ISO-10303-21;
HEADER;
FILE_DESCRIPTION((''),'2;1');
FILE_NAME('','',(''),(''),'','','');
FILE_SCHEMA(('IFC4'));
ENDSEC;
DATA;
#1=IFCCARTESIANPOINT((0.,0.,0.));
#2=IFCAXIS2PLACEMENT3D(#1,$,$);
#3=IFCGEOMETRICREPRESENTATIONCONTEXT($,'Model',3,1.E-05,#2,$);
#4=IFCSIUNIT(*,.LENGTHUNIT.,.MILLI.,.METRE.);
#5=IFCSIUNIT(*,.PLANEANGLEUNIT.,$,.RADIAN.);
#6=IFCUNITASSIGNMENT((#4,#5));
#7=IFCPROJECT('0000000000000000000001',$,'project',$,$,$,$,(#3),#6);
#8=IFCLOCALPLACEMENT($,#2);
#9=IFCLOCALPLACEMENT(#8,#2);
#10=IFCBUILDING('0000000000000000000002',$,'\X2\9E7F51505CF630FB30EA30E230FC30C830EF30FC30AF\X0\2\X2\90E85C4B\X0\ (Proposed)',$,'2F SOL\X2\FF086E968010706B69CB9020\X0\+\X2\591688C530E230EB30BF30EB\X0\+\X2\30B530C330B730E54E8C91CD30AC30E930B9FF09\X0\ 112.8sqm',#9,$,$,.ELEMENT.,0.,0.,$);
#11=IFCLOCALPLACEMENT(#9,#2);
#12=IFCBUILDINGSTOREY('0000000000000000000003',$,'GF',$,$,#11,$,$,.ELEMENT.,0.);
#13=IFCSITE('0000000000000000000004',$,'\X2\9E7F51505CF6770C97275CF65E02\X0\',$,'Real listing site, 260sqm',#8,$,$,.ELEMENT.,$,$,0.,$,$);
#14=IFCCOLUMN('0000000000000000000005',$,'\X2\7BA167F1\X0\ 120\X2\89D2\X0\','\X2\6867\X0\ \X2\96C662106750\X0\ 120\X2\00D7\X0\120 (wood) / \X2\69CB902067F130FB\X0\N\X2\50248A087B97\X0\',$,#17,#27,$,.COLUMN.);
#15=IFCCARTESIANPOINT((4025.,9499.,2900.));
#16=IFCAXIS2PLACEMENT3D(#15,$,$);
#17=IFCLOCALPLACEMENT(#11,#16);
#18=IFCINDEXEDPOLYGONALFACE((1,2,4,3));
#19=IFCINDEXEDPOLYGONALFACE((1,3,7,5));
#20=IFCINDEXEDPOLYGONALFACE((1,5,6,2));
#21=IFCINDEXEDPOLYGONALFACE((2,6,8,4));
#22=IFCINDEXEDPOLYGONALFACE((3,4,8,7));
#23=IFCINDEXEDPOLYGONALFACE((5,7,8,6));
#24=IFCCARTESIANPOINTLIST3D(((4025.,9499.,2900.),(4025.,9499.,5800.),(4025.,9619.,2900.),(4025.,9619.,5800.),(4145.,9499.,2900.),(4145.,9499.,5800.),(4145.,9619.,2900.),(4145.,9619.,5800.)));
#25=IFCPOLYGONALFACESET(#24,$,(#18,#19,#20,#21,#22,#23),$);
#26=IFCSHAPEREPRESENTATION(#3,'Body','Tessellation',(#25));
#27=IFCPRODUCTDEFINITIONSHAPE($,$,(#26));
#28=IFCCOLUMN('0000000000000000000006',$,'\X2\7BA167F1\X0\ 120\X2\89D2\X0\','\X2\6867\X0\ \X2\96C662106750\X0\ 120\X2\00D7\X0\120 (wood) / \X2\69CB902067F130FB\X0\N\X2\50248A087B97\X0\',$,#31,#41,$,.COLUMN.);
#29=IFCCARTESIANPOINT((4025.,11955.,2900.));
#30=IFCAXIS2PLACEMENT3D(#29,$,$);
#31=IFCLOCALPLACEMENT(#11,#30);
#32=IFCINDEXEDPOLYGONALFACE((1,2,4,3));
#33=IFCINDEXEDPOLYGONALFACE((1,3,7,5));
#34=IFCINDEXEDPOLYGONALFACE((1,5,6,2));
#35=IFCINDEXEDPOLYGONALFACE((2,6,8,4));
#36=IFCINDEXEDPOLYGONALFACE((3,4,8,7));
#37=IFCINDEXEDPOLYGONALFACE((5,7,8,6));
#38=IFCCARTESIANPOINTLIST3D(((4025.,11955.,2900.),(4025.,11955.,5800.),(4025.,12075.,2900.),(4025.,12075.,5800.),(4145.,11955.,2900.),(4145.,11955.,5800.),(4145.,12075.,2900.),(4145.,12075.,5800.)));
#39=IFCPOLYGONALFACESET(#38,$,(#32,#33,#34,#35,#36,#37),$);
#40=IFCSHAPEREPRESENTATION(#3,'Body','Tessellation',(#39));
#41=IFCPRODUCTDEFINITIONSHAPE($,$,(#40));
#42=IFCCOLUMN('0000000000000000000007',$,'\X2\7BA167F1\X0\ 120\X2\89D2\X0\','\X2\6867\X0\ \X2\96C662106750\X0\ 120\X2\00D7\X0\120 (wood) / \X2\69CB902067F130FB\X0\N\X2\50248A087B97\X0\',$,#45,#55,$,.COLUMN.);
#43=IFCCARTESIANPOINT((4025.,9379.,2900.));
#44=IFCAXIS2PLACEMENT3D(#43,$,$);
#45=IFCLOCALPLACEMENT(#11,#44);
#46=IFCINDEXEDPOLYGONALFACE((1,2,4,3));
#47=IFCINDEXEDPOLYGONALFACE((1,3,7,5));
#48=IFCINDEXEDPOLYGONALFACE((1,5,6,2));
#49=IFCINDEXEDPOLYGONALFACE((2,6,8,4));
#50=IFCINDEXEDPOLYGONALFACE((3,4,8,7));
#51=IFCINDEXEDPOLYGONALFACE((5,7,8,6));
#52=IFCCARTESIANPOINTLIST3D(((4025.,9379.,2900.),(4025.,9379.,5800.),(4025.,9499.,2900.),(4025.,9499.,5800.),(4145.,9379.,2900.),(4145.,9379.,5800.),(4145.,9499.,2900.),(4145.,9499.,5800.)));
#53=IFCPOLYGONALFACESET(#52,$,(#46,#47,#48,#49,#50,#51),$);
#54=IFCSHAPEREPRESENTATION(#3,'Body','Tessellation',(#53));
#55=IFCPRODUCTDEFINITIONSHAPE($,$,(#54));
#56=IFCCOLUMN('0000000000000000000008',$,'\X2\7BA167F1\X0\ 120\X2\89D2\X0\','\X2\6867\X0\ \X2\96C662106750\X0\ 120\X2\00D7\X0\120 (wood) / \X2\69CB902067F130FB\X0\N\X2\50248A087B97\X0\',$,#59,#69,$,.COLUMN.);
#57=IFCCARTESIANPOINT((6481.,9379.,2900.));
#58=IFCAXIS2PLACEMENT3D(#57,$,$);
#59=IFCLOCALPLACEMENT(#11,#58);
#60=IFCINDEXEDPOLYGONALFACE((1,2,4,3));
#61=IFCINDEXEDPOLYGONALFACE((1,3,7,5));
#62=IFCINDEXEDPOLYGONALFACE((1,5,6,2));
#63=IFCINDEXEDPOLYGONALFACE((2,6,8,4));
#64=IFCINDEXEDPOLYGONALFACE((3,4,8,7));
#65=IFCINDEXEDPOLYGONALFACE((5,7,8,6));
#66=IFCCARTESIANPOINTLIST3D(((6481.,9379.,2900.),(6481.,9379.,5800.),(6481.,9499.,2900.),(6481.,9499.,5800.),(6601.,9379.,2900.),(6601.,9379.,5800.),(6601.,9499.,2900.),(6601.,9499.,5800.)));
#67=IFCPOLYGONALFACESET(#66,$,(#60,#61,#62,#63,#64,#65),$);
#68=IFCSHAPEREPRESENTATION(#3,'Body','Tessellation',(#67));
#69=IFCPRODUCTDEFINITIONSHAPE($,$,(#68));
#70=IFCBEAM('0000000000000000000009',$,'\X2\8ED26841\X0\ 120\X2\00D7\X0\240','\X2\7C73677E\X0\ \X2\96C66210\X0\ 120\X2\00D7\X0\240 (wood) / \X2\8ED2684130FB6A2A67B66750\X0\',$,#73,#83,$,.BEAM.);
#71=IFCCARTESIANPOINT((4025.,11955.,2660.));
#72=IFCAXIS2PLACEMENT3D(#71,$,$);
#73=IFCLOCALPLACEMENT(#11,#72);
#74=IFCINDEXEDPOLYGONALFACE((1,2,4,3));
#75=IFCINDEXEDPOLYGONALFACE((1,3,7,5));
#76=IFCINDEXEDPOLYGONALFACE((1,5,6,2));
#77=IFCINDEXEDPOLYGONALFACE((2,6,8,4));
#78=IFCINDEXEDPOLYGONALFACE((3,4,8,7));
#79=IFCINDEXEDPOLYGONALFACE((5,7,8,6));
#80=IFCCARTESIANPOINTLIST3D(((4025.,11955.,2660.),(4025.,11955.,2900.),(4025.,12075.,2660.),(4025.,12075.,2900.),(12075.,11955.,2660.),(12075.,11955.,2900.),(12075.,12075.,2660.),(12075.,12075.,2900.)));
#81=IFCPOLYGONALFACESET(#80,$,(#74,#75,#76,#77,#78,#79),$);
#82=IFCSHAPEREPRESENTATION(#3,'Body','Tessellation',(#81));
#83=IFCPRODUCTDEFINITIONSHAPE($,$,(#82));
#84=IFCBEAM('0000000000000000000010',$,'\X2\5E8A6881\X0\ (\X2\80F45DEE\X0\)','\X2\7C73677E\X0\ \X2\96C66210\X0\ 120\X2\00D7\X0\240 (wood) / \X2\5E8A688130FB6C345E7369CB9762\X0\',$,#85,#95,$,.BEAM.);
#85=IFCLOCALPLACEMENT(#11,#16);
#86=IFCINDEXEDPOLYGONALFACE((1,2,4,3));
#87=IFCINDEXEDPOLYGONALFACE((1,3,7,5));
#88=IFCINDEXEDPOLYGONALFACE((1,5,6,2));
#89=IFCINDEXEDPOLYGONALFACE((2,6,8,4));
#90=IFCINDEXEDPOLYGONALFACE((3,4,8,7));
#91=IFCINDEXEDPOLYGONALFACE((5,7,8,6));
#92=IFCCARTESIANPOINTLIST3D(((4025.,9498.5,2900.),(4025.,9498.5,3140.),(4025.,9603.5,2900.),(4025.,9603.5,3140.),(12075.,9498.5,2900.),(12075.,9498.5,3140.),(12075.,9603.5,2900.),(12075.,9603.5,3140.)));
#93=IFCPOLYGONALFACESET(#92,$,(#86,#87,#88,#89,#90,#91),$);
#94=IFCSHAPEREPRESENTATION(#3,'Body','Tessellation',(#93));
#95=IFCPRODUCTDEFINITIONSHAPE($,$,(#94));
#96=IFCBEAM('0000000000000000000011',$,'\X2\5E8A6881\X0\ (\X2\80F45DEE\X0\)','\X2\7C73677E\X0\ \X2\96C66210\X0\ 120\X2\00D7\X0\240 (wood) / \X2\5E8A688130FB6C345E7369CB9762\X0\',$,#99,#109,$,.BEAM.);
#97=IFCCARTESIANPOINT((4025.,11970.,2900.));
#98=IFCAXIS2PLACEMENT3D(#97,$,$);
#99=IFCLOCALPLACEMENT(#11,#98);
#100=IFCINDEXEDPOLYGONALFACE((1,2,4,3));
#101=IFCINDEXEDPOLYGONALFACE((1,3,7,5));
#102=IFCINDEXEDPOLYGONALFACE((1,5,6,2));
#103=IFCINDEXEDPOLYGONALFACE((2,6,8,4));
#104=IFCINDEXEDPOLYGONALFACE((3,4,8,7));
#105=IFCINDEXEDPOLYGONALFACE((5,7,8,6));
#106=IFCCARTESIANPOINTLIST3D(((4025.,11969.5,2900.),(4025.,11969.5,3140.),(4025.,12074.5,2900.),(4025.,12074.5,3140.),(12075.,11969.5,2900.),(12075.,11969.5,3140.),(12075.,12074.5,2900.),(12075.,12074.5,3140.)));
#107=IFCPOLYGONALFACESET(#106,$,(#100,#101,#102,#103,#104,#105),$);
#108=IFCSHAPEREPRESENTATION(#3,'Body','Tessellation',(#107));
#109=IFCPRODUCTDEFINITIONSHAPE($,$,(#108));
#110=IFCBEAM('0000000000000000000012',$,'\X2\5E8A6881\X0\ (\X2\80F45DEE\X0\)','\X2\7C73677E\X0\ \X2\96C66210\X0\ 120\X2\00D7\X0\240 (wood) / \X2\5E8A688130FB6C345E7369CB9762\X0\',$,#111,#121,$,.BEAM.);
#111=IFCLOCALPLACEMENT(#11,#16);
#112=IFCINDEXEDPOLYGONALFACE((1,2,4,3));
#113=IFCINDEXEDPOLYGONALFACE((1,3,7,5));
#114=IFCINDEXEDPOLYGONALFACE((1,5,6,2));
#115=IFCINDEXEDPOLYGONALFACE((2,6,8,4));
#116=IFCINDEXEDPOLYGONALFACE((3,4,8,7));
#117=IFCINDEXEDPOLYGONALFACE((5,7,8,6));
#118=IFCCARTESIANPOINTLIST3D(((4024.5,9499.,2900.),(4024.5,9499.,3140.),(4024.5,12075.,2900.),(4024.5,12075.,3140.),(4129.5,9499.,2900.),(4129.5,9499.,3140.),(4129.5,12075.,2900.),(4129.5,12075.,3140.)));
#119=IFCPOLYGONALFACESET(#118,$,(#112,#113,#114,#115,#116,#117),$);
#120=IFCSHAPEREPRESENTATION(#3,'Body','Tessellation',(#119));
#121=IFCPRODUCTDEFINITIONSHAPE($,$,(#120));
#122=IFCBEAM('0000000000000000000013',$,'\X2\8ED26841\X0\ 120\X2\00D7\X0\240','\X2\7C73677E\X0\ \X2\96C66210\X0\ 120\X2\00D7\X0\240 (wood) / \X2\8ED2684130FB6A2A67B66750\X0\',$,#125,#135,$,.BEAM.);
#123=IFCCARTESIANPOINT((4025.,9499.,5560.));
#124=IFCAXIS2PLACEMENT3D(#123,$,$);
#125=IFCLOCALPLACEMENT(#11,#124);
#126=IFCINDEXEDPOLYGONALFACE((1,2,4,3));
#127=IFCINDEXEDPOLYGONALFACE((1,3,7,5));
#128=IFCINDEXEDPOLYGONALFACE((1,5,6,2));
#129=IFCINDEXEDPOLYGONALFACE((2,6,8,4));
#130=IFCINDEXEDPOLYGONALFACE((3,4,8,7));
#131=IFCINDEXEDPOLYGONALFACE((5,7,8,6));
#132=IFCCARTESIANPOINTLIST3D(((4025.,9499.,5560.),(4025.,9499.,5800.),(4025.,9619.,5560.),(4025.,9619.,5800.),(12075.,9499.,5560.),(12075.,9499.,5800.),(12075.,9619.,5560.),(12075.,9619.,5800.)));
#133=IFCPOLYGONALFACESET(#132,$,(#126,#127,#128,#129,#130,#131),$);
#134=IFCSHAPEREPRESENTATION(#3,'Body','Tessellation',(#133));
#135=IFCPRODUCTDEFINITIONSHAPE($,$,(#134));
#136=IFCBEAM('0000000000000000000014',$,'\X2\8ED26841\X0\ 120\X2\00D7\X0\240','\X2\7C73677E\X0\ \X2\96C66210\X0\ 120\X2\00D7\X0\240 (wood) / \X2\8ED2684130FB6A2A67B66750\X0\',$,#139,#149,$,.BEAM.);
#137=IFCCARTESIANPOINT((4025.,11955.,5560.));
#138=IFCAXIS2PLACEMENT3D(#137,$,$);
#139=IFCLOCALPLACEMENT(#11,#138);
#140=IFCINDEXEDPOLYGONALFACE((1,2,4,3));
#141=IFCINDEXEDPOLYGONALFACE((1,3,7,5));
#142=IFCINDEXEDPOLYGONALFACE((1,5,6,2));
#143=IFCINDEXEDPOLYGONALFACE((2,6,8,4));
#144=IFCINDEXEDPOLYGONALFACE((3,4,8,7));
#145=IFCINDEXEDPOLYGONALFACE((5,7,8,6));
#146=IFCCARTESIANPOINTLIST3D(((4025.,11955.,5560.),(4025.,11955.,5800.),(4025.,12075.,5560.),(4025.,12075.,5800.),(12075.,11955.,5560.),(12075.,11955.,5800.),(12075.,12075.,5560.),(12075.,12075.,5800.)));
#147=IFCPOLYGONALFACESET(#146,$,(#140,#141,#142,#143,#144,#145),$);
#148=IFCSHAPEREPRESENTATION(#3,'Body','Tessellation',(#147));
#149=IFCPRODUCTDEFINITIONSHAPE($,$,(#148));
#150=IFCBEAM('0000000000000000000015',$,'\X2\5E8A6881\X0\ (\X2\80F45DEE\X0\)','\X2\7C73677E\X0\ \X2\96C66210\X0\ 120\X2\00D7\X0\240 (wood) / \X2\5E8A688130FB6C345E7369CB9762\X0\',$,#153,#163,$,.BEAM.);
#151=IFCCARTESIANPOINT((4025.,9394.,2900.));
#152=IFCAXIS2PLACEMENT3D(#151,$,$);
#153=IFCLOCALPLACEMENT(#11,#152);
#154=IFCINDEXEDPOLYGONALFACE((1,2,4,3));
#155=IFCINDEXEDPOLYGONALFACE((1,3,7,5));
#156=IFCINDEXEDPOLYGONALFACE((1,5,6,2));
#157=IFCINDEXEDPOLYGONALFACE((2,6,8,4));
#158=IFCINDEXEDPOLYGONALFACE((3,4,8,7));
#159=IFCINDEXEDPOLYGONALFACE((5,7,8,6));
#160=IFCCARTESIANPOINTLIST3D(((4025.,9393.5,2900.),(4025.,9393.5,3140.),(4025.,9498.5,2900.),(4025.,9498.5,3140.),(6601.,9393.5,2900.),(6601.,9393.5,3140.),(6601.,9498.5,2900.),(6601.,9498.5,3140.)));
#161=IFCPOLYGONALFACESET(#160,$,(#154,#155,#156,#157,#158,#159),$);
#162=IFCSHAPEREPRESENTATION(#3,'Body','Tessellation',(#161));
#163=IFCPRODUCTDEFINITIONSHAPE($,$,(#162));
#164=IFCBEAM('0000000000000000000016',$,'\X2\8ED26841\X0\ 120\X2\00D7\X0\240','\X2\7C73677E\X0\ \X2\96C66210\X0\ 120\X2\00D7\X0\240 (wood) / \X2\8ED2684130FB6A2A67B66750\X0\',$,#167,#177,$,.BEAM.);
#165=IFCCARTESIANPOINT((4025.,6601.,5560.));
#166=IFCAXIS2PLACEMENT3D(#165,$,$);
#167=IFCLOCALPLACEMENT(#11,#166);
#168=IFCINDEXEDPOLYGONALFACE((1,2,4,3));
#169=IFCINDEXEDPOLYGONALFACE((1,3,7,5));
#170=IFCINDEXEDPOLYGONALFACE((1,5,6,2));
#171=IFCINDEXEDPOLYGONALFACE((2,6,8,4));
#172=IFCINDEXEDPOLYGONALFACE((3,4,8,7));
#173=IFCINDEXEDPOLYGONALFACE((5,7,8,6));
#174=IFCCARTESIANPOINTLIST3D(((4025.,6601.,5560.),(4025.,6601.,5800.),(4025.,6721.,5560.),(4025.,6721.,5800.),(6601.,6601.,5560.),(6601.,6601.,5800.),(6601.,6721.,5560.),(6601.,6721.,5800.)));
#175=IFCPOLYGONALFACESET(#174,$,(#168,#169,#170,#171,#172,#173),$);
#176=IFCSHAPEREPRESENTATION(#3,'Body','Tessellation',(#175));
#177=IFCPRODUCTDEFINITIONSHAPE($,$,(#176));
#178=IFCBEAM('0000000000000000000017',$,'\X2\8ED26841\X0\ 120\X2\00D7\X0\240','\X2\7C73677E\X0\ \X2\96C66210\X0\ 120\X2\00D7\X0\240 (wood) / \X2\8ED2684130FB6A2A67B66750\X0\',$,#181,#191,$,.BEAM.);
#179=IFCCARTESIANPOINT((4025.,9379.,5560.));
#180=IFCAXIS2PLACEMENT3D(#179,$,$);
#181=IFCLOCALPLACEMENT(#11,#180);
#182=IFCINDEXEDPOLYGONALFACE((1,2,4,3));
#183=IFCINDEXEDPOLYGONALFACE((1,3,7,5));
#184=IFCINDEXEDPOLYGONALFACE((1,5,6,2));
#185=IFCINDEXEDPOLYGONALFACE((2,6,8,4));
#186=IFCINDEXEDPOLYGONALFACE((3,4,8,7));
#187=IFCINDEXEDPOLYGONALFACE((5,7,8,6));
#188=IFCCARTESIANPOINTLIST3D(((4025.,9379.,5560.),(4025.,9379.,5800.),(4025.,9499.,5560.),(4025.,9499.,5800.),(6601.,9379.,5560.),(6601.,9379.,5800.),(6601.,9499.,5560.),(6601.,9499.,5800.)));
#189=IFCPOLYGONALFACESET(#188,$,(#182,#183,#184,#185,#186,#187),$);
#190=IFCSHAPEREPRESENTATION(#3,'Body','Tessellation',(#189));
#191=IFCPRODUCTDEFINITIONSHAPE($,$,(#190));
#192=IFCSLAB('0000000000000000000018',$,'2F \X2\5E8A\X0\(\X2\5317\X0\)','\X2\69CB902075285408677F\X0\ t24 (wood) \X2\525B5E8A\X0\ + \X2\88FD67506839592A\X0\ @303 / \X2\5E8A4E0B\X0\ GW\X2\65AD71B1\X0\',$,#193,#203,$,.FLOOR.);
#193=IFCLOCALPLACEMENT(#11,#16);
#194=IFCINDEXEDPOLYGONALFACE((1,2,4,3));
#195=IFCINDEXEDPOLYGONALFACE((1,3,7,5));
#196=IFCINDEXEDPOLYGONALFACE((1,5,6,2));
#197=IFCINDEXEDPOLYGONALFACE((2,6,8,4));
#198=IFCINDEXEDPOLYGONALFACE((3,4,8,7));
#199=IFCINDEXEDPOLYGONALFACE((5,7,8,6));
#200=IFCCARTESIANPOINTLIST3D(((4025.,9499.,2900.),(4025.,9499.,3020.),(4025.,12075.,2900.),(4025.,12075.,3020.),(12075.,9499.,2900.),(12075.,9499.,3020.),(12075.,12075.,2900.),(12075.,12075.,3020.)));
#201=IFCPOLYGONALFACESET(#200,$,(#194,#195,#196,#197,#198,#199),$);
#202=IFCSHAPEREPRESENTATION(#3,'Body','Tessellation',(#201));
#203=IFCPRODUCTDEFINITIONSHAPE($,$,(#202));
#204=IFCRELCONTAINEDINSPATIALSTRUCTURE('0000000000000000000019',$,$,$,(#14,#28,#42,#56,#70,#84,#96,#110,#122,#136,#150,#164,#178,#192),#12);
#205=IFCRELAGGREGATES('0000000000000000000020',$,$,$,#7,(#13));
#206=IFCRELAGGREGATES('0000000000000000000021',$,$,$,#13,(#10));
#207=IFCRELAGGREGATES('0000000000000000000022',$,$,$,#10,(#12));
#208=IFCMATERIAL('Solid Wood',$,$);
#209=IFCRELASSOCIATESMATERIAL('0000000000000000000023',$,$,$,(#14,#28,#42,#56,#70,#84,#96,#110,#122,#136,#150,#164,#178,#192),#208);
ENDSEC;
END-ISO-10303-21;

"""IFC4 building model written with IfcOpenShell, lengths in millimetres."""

from ifc_helpers import new_model, si_unit, frame, frame_2d, origin, place, context, project, spatial, rectangle, extrude, material, element, save


model = new_model("IFC4")

# Units and contexts
model_context = context("Model", 3, precision=1e-05, world=origin())
ifc_project = project(units=[si_unit("LENGTHUNIT", "METRE", prefix="MILLI"), si_unit("PLANEANGLEUNIT", "RADIAN")], contexts=[model_context])

# Site, building, storey
site_placement = place(None, origin())
site = spatial("IfcSite", under=ifc_project, at=site_placement, Name="鹿児島県霧島市", ObjectType="Real listing site, 260sqm", CompositionType="ELEMENT", RefElevation=0.0)
building_placement = place(site_placement, origin())
building = spatial("IfcBuilding", under=site, at=building_placement, Name="鹿児島・リモートワーク2部屋 (Proposed)", ObjectType="2F SOL（準耐火構造+外装モルタル+サッシュ二重ガラス） 112.8sqm", CompositionType="ELEMENT", ElevationOfRefHeight=0.0, ElevationOfTerrain=0.0)
storey_placement = place(building_placement, origin())
storey = spatial("IfcBuildingStorey", under=building, at=storey_placement, Name="GF", CompositionType="ELEMENT", Elevation=0.0)

# Columns
ifc_material_1 = material(Name="Solid Wood")
column_1_placement = place(storey_placement, frame((4025.0, 9499.0, 2900.0)))
element("IfcColumn", 1, at=column_1_placement, inside=storey, material=ifc_material_1, Name="管柱 120角", Description="桧 集成材 120×120 (wood) / 構造柱・N値計算", PredefinedType="COLUMN", context=model_context, shape_type="SweptSolid", body=[
    extrude(rectangle(XDim=120.0, YDim=120.0, at=frame_2d((60.0, 60.0))), frame((4025.0, 9499.0, 2900.0)), (0.0, 0.0, 1.0), 2900.0),
])
column_2_placement = place(storey_placement, frame((4025.0, 11955.0, 2900.0)))
element("IfcColumn", 2, at=column_2_placement, inside=storey, material=ifc_material_1, Name="管柱 120角", Description="桧 集成材 120×120 (wood) / 構造柱・N値計算", PredefinedType="COLUMN", context=model_context, shape_type="SweptSolid", body=[
    extrude(rectangle(XDim=120.0, YDim=120.0, at=frame_2d((60.0, 60.0))), frame((4025.0, 11955.0, 2900.0)), (0.0, 0.0, 1.0), 2900.0),
])
column_3_placement = place(storey_placement, frame((4025.0, 9379.0, 2900.0)))
element("IfcColumn", 3, at=column_3_placement, inside=storey, material=ifc_material_1, Name="管柱 120角", Description="桧 集成材 120×120 (wood) / 構造柱・N値計算", PredefinedType="COLUMN", context=model_context, shape_type="SweptSolid", body=[
    extrude(rectangle(XDim=120.0, YDim=120.0, at=frame_2d((60.0, 60.0))), frame((4025.0, 9379.0, 2900.0)), (0.0, 0.0, 1.0), 2900.0),
])
column_4_placement = place(storey_placement, frame((6481.0, 9379.0, 2900.0)))
element("IfcColumn", 4, at=column_4_placement, inside=storey, material=ifc_material_1, Name="管柱 120角", Description="桧 集成材 120×120 (wood) / 構造柱・N値計算", PredefinedType="COLUMN", context=model_context, shape_type="SweptSolid", body=[
    extrude(rectangle(XDim=120.0, YDim=120.0, at=frame_2d((60.0, 60.0))), frame((6481.0, 9379.0, 2900.0)), (0.0, 0.0, 1.0), 2900.0),
])

# Beams
beam_1_placement = place(storey_placement, frame((4025.0, 11955.0, 2660.0)))
element("IfcBeam", 5, at=beam_1_placement, inside=storey, material=ifc_material_1, Name="軒桁 120×240", Description="米松 集成 120×240 (wood) / 軒桁・横架材", PredefinedType="BEAM", context=model_context, shape_type="SweptSolid", body=[
    extrude(rectangle(XDim=8050.0, YDim=120.0, at=frame_2d((4025.0, 60.0))), frame((4025.0, 11955.0, 2660.0)), (0.0, 0.0, 1.0), 240.0),
])
beam_2_placement = place(storey_placement, frame((4025.0, 9499.0, 2900.0)))
element("IfcBeam", 6, at=beam_2_placement, inside=storey, material=ifc_material_1, Name="床梁 (胴差)", Description="米松 集成 120×240 (wood) / 床梁・水平構面", PredefinedType="BEAM", context=model_context, shape_type="SweptSolid", body=[
    extrude(rectangle(XDim=8050.0, YDim=105.0, at=frame_2d((4025.0, 52.0))), frame((4025.0, 9499.0, 2900.0)), (0.0, 0.0, 1.0), 240.0),
])
beam_3_placement = place(storey_placement, frame((4025.0, 11970.0, 2900.0)))
element("IfcBeam", 7, at=beam_3_placement, inside=storey, material=ifc_material_1, Name="床梁 (胴差)", Description="米松 集成 120×240 (wood) / 床梁・水平構面", PredefinedType="BEAM", context=model_context, shape_type="SweptSolid", body=[
    extrude(rectangle(XDim=8050.0, YDim=105.0, at=frame_2d((4025.0, 52.0))), frame((4025.0, 11970.0, 2900.0)), (0.0, 0.0, 1.0), 240.0),
])
beam_4_placement = place(storey_placement, frame((4025.0, 9499.0, 2900.0)))
element("IfcBeam", 8, at=beam_4_placement, inside=storey, material=ifc_material_1, Name="床梁 (胴差)", Description="米松 集成 120×240 (wood) / 床梁・水平構面", PredefinedType="BEAM", context=model_context, shape_type="SweptSolid", body=[
    extrude(rectangle(XDim=105.0, YDim=2576.0, at=frame_2d((52.0, 1288.0))), frame((4025.0, 9499.0, 2900.0)), (0.0, 0.0, 1.0), 240.0),
])
beam_5_placement = place(storey_placement, frame((4025.0, 9499.0, 5560.0)))
element("IfcBeam", 9, at=beam_5_placement, inside=storey, material=ifc_material_1, Name="軒桁 120×240", Description="米松 集成 120×240 (wood) / 軒桁・横架材", PredefinedType="BEAM", context=model_context, shape_type="SweptSolid", body=[
    extrude(rectangle(XDim=8050.0, YDim=120.0, at=frame_2d((4025.0, 60.0))), frame((4025.0, 9499.0, 5560.0)), (0.0, 0.0, 1.0), 240.0),
])
beam_6_placement = place(storey_placement, frame((4025.0, 11955.0, 5560.0)))
element("IfcBeam", 10, at=beam_6_placement, inside=storey, material=ifc_material_1, Name="軒桁 120×240", Description="米松 集成 120×240 (wood) / 軒桁・横架材", PredefinedType="BEAM", context=model_context, shape_type="SweptSolid", body=[
    extrude(rectangle(XDim=8050.0, YDim=120.0, at=frame_2d((4025.0, 60.0))), frame((4025.0, 11955.0, 5560.0)), (0.0, 0.0, 1.0), 240.0),
])
beam_7_placement = place(storey_placement, frame((4025.0, 9394.0, 2900.0)))
element("IfcBeam", 11, at=beam_7_placement, inside=storey, material=ifc_material_1, Name="床梁 (胴差)", Description="米松 集成 120×240 (wood) / 床梁・水平構面", PredefinedType="BEAM", context=model_context, shape_type="SweptSolid", body=[
    extrude(rectangle(XDim=2576.0, YDim=105.0, at=frame_2d((1288.0, 52.0))), frame((4025.0, 9394.0, 2900.0)), (0.0, 0.0, 1.0), 240.0),
])
beam_8_placement = place(storey_placement, frame((4025.0, 6601.0, 5560.0)))
element("IfcBeam", 12, at=beam_8_placement, inside=storey, material=ifc_material_1, Name="軒桁 120×240", Description="米松 集成 120×240 (wood) / 軒桁・横架材", PredefinedType="BEAM", context=model_context, shape_type="SweptSolid", body=[
    extrude(rectangle(XDim=2576.0, YDim=120.0, at=frame_2d((1288.0, 60.0))), frame((4025.0, 6601.0, 5560.0)), (0.0, 0.0, 1.0), 240.0),
])
beam_9_placement = place(storey_placement, frame((4025.0, 9379.0, 5560.0)))
element("IfcBeam", 13, at=beam_9_placement, inside=storey, material=ifc_material_1, Name="軒桁 120×240", Description="米松 集成 120×240 (wood) / 軒桁・横架材", PredefinedType="BEAM", context=model_context, shape_type="SweptSolid", body=[
    extrude(rectangle(XDim=2576.0, YDim=120.0, at=frame_2d((1288.0, 60.0))), frame((4025.0, 9379.0, 5560.0)), (0.0, 0.0, 1.0), 240.0),
])

# Slab
slab_placement = place(storey_placement, frame((4025.0, 9499.0, 2900.0)))
element("IfcSlab", 14, at=slab_placement, inside=storey, material=ifc_material_1, Name="2F 床(北)", Description="構造用合板 t24 (wood) 剛床 + 製材根太 @303 / 床下 GW断熱", PredefinedType="FLOOR", context=model_context, shape_type="SweptSolid", body=[
    extrude(rectangle(XDim=8050.0, YDim=2576.0, at=frame_2d((4025.0, 1288.0))), frame((4025.0, 9499.0, 2900.0)), (0.0, 0.0, 1.0), 120.0),
])

save(model, "model.ifc")
